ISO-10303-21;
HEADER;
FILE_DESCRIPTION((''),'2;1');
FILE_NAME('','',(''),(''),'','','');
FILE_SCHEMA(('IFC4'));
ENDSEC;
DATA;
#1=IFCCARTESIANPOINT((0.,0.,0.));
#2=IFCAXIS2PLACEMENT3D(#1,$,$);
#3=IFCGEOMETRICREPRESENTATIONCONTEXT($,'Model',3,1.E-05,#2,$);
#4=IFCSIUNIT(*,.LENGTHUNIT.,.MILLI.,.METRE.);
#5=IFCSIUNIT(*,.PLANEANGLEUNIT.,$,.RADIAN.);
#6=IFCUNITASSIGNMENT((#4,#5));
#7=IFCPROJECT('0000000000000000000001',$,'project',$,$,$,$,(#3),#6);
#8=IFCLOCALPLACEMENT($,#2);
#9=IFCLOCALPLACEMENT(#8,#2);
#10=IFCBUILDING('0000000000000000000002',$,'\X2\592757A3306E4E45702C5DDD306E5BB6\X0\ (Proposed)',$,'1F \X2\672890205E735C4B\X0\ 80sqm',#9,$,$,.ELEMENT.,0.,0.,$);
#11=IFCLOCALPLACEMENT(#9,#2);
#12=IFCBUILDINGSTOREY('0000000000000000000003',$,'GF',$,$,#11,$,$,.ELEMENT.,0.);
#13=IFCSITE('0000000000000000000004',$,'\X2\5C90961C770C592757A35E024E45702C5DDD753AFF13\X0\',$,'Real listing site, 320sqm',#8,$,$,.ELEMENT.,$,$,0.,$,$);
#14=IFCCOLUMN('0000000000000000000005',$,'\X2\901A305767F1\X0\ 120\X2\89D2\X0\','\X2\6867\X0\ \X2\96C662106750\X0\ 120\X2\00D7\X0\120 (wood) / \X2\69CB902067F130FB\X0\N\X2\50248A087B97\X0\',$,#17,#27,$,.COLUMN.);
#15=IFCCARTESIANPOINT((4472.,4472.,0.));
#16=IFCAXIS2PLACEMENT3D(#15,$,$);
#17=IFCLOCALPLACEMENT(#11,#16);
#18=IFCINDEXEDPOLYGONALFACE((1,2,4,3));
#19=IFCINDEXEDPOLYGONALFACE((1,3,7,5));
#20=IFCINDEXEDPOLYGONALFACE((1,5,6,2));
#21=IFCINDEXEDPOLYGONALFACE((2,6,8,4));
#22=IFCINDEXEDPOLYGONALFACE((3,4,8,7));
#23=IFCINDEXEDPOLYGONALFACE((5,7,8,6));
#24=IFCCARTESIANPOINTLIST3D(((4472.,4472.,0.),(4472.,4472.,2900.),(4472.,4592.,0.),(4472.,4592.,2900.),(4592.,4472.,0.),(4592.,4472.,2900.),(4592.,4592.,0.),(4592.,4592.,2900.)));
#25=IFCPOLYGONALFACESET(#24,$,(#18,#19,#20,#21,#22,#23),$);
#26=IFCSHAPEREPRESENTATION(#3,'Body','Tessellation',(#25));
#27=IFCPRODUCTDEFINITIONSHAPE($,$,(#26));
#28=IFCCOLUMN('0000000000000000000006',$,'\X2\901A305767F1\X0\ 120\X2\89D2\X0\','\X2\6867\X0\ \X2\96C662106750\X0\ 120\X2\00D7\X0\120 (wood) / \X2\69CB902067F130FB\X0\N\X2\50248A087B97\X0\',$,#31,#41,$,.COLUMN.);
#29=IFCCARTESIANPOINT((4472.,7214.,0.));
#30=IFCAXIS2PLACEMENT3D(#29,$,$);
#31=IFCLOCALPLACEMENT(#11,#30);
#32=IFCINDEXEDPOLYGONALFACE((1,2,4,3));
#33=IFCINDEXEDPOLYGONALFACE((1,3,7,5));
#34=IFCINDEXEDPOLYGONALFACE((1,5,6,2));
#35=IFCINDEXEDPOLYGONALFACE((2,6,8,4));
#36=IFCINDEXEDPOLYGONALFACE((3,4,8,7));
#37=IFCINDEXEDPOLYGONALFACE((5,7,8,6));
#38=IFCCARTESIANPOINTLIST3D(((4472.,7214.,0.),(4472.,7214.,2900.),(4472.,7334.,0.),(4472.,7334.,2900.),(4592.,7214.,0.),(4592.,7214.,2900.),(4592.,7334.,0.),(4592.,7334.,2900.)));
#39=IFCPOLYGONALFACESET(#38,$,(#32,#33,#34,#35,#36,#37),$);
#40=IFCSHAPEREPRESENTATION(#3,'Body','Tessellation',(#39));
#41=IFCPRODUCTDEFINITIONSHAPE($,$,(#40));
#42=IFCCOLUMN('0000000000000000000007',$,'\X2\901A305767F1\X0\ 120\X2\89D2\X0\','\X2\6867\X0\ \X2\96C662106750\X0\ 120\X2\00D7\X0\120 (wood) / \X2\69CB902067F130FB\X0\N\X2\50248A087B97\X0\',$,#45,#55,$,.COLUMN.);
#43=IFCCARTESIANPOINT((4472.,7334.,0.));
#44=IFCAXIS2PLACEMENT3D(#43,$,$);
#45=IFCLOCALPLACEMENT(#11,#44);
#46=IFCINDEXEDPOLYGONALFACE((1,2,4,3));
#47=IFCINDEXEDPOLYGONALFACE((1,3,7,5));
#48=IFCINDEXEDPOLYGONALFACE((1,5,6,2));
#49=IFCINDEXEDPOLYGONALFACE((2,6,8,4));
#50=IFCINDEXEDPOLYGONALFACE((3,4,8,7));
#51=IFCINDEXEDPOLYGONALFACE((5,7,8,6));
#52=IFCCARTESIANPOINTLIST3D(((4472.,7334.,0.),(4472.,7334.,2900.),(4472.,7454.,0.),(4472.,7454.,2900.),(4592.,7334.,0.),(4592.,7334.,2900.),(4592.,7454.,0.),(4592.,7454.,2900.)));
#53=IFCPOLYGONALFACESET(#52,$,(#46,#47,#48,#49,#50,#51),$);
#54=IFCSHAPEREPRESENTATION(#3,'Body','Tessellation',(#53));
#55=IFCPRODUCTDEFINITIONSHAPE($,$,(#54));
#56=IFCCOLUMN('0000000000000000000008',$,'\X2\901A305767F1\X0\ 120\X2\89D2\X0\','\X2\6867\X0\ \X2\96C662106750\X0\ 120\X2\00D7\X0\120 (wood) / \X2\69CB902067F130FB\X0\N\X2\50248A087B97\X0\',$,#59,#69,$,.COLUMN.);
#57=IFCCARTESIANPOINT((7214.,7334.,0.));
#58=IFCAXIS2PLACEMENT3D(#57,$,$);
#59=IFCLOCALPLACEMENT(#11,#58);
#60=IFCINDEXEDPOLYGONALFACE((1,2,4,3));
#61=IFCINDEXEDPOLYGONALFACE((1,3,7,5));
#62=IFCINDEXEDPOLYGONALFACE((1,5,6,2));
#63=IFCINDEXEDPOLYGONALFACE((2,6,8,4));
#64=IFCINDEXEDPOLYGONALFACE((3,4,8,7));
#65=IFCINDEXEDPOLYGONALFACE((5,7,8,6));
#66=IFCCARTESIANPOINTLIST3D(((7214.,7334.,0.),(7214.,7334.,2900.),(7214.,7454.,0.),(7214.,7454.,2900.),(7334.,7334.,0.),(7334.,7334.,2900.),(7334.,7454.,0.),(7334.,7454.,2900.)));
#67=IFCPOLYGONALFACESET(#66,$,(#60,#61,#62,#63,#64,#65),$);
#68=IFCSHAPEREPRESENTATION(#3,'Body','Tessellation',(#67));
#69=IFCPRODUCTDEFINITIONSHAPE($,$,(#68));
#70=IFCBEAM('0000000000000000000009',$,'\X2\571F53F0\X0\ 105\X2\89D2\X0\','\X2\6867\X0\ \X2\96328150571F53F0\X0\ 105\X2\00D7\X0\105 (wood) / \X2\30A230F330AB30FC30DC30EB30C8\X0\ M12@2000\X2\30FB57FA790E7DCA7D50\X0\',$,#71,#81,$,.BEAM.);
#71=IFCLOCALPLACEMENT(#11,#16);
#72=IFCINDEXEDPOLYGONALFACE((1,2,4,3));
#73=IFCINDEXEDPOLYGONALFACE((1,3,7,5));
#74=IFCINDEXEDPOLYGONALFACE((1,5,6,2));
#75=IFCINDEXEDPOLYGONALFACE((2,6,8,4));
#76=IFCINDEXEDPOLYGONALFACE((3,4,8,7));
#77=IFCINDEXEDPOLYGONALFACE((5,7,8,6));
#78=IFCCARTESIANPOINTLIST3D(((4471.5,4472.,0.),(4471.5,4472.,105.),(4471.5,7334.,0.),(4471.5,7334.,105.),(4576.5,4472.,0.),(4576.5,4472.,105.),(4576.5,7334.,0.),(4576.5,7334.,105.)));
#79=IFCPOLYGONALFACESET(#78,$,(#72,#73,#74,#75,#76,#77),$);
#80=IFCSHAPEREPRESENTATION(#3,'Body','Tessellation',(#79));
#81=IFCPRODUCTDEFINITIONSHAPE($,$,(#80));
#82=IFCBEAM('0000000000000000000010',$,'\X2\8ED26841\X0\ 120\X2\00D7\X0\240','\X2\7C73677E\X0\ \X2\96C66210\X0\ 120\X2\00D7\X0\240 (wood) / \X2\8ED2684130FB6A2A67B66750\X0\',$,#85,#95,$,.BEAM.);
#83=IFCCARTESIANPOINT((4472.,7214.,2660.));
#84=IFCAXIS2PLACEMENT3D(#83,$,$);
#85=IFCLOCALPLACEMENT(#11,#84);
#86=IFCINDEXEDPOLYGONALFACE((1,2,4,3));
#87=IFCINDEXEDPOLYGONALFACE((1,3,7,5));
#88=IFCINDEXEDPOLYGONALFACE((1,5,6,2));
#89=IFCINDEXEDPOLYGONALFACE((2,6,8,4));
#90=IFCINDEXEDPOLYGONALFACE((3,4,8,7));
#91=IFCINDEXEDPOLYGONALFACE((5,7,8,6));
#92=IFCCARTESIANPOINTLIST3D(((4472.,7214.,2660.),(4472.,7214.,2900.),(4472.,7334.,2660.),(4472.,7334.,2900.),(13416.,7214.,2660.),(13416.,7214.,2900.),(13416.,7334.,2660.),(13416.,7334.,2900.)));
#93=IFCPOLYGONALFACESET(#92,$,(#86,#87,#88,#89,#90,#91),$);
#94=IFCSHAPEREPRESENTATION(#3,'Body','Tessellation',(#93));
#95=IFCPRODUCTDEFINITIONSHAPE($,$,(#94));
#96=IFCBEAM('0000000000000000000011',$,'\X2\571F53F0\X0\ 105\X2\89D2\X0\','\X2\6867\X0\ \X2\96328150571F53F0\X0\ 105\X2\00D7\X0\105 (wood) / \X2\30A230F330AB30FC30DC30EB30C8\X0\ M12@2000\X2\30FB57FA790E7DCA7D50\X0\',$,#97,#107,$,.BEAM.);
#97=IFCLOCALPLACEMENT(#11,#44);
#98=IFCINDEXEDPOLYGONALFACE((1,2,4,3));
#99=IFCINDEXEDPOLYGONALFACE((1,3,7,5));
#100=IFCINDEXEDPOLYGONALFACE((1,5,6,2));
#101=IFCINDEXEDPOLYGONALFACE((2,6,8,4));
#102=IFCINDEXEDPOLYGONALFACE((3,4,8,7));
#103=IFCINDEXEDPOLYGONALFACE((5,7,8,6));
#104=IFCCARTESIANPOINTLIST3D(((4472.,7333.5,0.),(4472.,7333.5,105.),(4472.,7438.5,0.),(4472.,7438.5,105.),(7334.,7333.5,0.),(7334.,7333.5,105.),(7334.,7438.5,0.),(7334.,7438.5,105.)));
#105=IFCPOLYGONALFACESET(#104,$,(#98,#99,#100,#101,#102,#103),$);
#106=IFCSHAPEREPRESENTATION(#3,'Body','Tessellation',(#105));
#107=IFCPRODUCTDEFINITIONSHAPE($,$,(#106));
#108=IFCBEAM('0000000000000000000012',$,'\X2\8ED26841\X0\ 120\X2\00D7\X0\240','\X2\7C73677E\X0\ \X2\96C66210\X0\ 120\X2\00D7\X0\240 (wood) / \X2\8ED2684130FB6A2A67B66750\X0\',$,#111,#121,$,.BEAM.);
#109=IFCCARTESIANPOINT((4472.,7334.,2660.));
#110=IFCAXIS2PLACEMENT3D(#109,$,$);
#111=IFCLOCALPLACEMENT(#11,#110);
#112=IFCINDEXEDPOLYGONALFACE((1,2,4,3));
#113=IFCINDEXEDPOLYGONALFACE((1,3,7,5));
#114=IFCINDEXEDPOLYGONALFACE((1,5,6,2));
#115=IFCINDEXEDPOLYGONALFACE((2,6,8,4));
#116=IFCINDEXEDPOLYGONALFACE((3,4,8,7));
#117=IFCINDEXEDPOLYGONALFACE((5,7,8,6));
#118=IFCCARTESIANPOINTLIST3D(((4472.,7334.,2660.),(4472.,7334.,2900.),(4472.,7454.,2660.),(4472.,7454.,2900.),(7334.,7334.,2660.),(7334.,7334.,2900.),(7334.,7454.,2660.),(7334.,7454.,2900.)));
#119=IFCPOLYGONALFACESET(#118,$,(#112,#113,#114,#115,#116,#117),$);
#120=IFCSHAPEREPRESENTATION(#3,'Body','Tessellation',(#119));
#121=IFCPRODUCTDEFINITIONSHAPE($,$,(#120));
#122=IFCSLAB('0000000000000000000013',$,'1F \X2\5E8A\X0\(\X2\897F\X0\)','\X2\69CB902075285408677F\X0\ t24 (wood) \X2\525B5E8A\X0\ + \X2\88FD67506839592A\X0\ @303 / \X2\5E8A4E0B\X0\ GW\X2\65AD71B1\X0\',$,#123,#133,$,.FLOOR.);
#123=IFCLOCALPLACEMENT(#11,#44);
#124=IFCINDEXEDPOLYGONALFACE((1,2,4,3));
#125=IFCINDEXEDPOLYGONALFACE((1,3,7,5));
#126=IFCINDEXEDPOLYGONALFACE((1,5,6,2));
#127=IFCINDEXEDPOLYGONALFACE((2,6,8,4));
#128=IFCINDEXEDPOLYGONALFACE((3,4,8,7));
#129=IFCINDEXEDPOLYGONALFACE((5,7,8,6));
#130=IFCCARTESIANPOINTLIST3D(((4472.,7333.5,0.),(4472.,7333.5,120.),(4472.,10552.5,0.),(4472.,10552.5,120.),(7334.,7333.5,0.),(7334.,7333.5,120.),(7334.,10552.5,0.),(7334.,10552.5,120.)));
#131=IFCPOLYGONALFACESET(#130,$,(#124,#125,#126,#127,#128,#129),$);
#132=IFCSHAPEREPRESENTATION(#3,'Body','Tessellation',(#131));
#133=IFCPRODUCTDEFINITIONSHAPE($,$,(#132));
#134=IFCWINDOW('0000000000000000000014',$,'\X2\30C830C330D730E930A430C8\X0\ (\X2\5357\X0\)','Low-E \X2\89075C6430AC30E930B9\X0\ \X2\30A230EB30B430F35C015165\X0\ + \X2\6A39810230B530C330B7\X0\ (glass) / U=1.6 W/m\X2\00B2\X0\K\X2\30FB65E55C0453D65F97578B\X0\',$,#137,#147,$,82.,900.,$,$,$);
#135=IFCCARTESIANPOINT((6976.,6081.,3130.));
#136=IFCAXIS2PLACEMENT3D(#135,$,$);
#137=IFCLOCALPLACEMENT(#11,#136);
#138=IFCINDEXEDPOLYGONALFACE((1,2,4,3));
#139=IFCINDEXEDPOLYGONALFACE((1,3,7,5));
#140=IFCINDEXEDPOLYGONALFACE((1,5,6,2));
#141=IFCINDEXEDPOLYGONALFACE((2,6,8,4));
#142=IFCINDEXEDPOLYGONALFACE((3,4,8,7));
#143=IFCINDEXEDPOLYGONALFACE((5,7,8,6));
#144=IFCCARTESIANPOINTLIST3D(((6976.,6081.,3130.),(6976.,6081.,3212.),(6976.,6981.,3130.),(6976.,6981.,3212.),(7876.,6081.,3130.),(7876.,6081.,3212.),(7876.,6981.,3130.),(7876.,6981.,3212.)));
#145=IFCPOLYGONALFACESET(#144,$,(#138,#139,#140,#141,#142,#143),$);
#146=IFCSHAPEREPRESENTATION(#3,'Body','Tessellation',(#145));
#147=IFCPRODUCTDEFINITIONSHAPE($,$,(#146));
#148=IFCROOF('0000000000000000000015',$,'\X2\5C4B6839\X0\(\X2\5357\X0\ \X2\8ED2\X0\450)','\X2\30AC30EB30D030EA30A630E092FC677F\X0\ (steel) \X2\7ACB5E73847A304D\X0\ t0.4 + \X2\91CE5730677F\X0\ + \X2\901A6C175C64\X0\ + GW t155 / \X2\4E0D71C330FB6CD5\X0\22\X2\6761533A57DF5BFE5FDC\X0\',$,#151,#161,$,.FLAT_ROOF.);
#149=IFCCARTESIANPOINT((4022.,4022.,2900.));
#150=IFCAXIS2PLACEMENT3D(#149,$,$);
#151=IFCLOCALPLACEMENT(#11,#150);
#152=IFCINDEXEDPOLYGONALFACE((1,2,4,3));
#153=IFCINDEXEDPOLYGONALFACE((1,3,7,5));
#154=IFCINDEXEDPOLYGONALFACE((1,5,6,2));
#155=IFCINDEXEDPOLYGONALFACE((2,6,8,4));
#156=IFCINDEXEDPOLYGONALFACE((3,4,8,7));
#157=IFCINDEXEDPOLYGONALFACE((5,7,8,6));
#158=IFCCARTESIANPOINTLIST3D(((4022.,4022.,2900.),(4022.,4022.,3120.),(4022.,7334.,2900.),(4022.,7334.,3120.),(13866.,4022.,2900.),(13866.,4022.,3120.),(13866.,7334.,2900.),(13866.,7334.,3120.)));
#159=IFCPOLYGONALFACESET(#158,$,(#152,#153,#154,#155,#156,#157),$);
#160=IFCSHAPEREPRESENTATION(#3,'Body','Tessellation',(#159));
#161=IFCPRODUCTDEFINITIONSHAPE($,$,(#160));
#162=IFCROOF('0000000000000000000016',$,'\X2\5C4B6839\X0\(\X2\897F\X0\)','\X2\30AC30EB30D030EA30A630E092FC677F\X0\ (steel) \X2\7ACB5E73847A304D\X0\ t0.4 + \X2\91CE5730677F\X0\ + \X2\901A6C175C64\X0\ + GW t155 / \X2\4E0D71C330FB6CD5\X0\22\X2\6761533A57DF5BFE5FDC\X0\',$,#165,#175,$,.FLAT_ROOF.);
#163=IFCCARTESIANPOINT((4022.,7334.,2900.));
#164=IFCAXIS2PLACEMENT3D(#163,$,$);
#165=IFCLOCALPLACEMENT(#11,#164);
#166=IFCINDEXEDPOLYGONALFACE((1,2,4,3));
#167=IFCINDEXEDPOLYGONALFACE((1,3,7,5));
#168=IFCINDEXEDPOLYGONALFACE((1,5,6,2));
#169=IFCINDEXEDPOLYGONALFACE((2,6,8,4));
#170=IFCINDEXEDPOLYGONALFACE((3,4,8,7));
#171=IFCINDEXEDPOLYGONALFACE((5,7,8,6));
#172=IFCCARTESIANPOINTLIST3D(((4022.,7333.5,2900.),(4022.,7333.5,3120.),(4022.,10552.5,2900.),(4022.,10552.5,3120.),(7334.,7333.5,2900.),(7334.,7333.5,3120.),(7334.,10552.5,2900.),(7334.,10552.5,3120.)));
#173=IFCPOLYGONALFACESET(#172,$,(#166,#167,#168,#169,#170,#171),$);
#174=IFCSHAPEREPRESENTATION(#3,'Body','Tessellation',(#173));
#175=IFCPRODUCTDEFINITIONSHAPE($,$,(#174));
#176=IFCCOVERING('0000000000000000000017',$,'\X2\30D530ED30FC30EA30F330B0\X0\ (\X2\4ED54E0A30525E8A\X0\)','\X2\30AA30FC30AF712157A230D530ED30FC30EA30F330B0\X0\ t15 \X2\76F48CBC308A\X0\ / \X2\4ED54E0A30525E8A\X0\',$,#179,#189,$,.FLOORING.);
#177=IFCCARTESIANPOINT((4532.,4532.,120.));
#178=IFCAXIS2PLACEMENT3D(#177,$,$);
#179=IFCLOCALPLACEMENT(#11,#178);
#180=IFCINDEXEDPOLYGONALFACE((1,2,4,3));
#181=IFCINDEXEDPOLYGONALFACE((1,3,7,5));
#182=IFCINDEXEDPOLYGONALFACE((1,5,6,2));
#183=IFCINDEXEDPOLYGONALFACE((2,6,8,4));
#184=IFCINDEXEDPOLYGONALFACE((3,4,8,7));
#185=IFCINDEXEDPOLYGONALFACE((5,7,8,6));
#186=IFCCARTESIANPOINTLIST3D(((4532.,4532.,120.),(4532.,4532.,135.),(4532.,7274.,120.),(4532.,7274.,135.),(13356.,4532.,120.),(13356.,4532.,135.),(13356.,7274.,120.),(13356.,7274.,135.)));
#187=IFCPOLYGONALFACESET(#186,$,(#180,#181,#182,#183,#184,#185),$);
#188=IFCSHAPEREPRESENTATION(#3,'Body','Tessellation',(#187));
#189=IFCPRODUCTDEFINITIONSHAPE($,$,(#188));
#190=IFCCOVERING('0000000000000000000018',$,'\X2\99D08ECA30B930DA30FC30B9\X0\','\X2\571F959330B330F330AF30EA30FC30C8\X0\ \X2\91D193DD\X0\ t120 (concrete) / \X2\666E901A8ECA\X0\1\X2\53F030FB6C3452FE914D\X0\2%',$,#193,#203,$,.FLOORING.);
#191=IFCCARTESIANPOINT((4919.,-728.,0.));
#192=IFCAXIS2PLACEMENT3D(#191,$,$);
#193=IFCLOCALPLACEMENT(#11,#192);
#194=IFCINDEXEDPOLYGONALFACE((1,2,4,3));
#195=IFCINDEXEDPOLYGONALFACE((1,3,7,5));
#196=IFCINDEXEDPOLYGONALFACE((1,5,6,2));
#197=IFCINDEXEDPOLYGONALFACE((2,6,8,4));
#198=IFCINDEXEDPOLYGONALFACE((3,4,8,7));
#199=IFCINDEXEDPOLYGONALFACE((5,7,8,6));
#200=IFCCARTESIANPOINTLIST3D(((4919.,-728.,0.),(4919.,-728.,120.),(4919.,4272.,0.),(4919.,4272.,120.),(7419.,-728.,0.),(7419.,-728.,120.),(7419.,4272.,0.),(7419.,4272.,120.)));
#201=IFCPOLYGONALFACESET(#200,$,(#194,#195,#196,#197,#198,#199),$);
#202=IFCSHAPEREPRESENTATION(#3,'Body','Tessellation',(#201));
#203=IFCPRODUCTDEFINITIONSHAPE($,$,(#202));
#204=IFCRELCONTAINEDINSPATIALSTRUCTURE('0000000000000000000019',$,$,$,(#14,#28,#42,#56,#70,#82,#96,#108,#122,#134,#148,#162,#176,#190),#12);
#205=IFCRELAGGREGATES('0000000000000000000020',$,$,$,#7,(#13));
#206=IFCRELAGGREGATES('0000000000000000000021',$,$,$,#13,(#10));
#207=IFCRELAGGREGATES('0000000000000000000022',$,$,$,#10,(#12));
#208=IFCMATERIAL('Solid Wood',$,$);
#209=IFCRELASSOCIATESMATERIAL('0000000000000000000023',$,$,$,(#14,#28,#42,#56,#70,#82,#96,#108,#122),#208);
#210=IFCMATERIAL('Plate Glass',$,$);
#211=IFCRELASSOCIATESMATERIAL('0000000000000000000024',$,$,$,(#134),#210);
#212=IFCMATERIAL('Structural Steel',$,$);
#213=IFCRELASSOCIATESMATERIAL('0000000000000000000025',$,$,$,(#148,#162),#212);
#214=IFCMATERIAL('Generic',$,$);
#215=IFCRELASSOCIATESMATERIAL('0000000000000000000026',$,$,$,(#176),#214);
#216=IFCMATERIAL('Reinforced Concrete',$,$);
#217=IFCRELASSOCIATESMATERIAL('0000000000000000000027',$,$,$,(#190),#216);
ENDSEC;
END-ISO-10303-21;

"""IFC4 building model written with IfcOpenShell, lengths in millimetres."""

from ifc_helpers import new_model, si_unit, frame, frame_2d, origin, place, context, project, spatial, rectangle, extrude, material, element, save


model = new_model("IFC4")

# Units and contexts
model_context = context("Model", 3, precision=1e-05, world=origin())
ifc_project = project(units=[si_unit("LENGTHUNIT", "METRE", prefix="MILLI"), si_unit("PLANEANGLEUNIT", "RADIAN")], contexts=[model_context])

# Site, building, storey
site_placement = place(None, origin())
site = spatial("IfcSite", under=ifc_project, at=site_placement, Name="岐阜県大垣市久瀬川町３", ObjectType="Real listing site, 320sqm", CompositionType="ELEMENT", RefElevation=0.0)
building_placement = place(site_placement, origin())
building = spatial("IfcBuilding", under=site, at=building_placement, Name="大垣の久瀬川の家 (Proposed)", ObjectType="1F 木造平屋 80sqm", CompositionType="ELEMENT", ElevationOfRefHeight=0.0, ElevationOfTerrain=0.0)
storey_placement = place(building_placement, origin())
storey = spatial("IfcBuildingStorey", under=building, at=storey_placement, Name="GF", CompositionType="ELEMENT", Elevation=0.0)

# Columns
ifc_material_1 = material(Name="Solid Wood")
column_1_placement = place(storey_placement, frame((4472.0, 4472.0, 0.0)))
element("IfcColumn", 1, at=column_1_placement, inside=storey, material=ifc_material_1, Name="通し柱 120角", Description="桧 集成材 120×120 (wood) / 構造柱・N値計算", PredefinedType="COLUMN", context=model_context, shape_type="SweptSolid", body=[
    extrude(rectangle(XDim=120.0, YDim=120.0, at=frame_2d((60.0, 60.0))), frame((4472.0, 4472.0, 0.0)), (0.0, 0.0, 1.0), 2900.0),
])
column_2_placement = place(storey_placement, frame((4472.0, 7214.0, 0.0)))
element("IfcColumn", 2, at=column_2_placement, inside=storey, material=ifc_material_1, Name="通し柱 120角", Description="桧 集成材 120×120 (wood) / 構造柱・N値計算", PredefinedType="COLUMN", context=model_context, shape_type="SweptSolid", body=[
    extrude(rectangle(XDim=120.0, YDim=120.0, at=frame_2d((60.0, 60.0))), frame((4472.0, 7214.0, 0.0)), (0.0, 0.0, 1.0), 2900.0),
])
column_3_placement = place(storey_placement, frame((4472.0, 7334.0, 0.0)))
element("IfcColumn", 3, at=column_3_placement, inside=storey, material=ifc_material_1, Name="通し柱 120角", Description="桧 集成材 120×120 (wood) / 構造柱・N値計算", PredefinedType="COLUMN", context=model_context, shape_type="SweptSolid", body=[
    extrude(rectangle(XDim=120.0, YDim=120.0, at=frame_2d((60.0, 60.0))), frame((4472.0, 7334.0, 0.0)), (0.0, 0.0, 1.0), 2900.0),
])
column_4_placement = place(storey_placement, frame((7214.0, 7334.0, 0.0)))
element("IfcColumn", 4, at=column_4_placement, inside=storey, material=ifc_material_1, Name="通し柱 120角", Description="桧 集成材 120×120 (wood) / 構造柱・N値計算", PredefinedType="COLUMN", context=model_context, shape_type="SweptSolid", body=[
    extrude(rectangle(XDim=120.0, YDim=120.0, at=frame_2d((60.0, 60.0))), frame((7214.0, 7334.0, 0.0)), (0.0, 0.0, 1.0), 2900.0),
])

# Beams
beam_1_placement = place(storey_placement, frame((4472.0, 4472.0, 0.0)))
element("IfcBeam", 5, at=beam_1_placement, inside=storey, material=ifc_material_1, Name="土台 105角", Description="桧 防腐土台 105×105 (wood) / アンカーボルト M12@2000・基礎緊結", PredefinedType="BEAM", context=model_context, shape_type="SweptSolid", body=[
    extrude(rectangle(XDim=105.0, YDim=2862.0, at=frame_2d((52.0, 1431.0))), frame((4472.0, 4472.0, 0.0)), (0.0, 0.0, 1.0), 105.0),
])
beam_2_placement = place(storey_placement, frame((4472.0, 7214.0, 2660.0)))
element("IfcBeam", 6, at=beam_2_placement, inside=storey, material=ifc_material_1, Name="軒桁 120×240", Description="米松 集成 120×240 (wood) / 軒桁・横架材", PredefinedType="BEAM", context=model_context, shape_type="SweptSolid", body=[
    extrude(rectangle(XDim=8944.0, YDim=120.0, at=frame_2d((4472.0, 60.0))), frame((4472.0, 7214.0, 2660.0)), (0.0, 0.0, 1.0), 240.0),
])
beam_3_placement = place(storey_placement, frame((4472.0, 7334.0, 0.0)))
element("IfcBeam", 7, at=beam_3_placement, inside=storey, material=ifc_material_1, Name="土台 105角", Description="桧 防腐土台 105×105 (wood) / アンカーボルト M12@2000・基礎緊結", PredefinedType="BEAM", context=model_context, shape_type="SweptSolid", body=[
    extrude(rectangle(XDim=2862.0, YDim=105.0, at=frame_2d((1431.0, 52.0))), frame((4472.0, 7334.0, 0.0)), (0.0, 0.0, 1.0), 105.0),
])
beam_4_placement = place(storey_placement, frame((4472.0, 7334.0, 2660.0)))
element("IfcBeam", 8, at=beam_4_placement, inside=storey, material=ifc_material_1, Name="軒桁 120×240", Description="米松 集成 120×240 (wood) / 軒桁・横架材", PredefinedType="BEAM", context=model_context, shape_type="SweptSolid", body=[
    extrude(rectangle(XDim=2862.0, YDim=120.0, at=frame_2d((1431.0, 60.0))), frame((4472.0, 7334.0, 2660.0)), (0.0, 0.0, 1.0), 240.0),
])

# Slab
ifc_material_2 = material(Name="Reinforced Concrete")
slab_1_placement = place(storey_placement, frame((4472.0, 7334.0, 0.0)))
element("IfcSlab", 9, at=slab_1_placement, inside=storey, material=ifc_material_1, Name="1F 床(西)", Description="構造用合板 t24 (wood) 剛床 + 製材根太 @303 / 床下 GW断熱", PredefinedType="FLOOR", context=model_context, shape_type="SweptSolid", body=[
    extrude(rectangle(XDim=2862.0, YDim=3219.0, at=frame_2d((1431.0, 1609.0))), frame((4472.0, 7334.0, 0.0)), (0.0, 0.0, 1.0), 120.0),
])

# Shared definitions
ifc_material_3 = material(Name="Plate Glass")

# Window
window_1_placement = place(storey_placement, frame((6976.0, 6081.0, 3130.0)))
element("IfcWindow", 10, at=window_1_placement, inside=storey, material=ifc_material_3, Name="トップライト (南)", Description="Low-E 複層ガラス アルゴン封入 + 樹脂サッシ (glass) / U=1.6 W/m²K・日射取得型", OverallHeight=82.0, OverallWidth=900.0, context=model_context, shape_type="SweptSolid", body=[
    extrude(rectangle(XDim=900.0, YDim=900.0, at=frame_2d((450.0, 450.0))), frame((6976.0, 6081.0, 3130.0)), (0.0, 0.0, 1.0), 82.0),
])

# Roofs
ifc_material_4 = material(Name="Structural Steel")
roof_1_placement = place(storey_placement, frame((4022.0, 4022.0, 2900.0)))
element("IfcRoof", 11, at=roof_1_placement, inside=storey, material=ifc_material_4, Name="屋根(南 軒450)", Description="ガルバリウム鋼板 (steel) 立平葺き t0.4 + 野地板 + 通気層 + GW t155 / 不燃・法22条区域対応", PredefinedType="FLAT_ROOF", context=model_context, shape_type="SweptSolid", body=[
    extrude(rectangle(XDim=9844.0, YDim=3312.0, at=frame_2d((4922.0, 1656.0))), frame((4022.0, 4022.0, 2900.0)), (0.0, 0.0, 1.0), 220.0),
])
roof_2_placement = place(storey_placement, frame((4022.0, 7334.0, 2900.0)))
element("IfcRoof", 12, at=roof_2_placement, inside=storey, material=ifc_material_4, Name="屋根(西)", Description="ガルバリウム鋼板 (steel) 立平葺き t0.4 + 野地板 + 通気層 + GW t155 / 不燃・法22条区域対応", PredefinedType="FLAT_ROOF", context=model_context, shape_type="SweptSolid", body=[
    extrude(rectangle(XDim=3312.0, YDim=3219.0, at=frame_2d((1656.0, 1609.0))), frame((4022.0, 7334.0, 2900.0)), (0.0, 0.0, 1.0), 220.0),
])

# Coverings
ifc_material_5 = material(Name="Generic")
covering_1_placement = place(storey_placement, frame((4532.0, 4532.0, 120.0)))
element("IfcCovering", 13, at=covering_1_placement, inside=storey, material=ifc_material_5, Name="フローリング (仕上げ床)", Description="オーク無垢フローリング t15 直貼り / 仕上げ床", PredefinedType="FLOORING", context=model_context, shape_type="SweptSolid", body=[
    extrude(rectangle(XDim=8824.0, YDim=2742.0, at=frame_2d((4412.0, 1371.0))), frame((4532.0, 4532.0, 120.0)), (0.0, 0.0, 1.0), 15.0),
])
covering_2_placement = place(storey_placement, frame((4919.0, -728.0, 0.0)))
element("IfcCovering", 14, at=covering_2_placement, inside=storey, material=ifc_material_2, Name="駐車スペース", Description="土間コンクリート 金鏝 t120 (concrete) / 普通車1台・水勾配2%", PredefinedType="FLOORING", context=model_context, shape_type="SweptSolid", body=[
    extrude(rectangle(XDim=2500.0, YDim=5000.0, at=frame_2d((1250.0, 2500.0))), frame((4919.0, -728.0, 0.0)), (0.0, 0.0, 1.0), 120.0),
])

save(model, "model.ifc")
